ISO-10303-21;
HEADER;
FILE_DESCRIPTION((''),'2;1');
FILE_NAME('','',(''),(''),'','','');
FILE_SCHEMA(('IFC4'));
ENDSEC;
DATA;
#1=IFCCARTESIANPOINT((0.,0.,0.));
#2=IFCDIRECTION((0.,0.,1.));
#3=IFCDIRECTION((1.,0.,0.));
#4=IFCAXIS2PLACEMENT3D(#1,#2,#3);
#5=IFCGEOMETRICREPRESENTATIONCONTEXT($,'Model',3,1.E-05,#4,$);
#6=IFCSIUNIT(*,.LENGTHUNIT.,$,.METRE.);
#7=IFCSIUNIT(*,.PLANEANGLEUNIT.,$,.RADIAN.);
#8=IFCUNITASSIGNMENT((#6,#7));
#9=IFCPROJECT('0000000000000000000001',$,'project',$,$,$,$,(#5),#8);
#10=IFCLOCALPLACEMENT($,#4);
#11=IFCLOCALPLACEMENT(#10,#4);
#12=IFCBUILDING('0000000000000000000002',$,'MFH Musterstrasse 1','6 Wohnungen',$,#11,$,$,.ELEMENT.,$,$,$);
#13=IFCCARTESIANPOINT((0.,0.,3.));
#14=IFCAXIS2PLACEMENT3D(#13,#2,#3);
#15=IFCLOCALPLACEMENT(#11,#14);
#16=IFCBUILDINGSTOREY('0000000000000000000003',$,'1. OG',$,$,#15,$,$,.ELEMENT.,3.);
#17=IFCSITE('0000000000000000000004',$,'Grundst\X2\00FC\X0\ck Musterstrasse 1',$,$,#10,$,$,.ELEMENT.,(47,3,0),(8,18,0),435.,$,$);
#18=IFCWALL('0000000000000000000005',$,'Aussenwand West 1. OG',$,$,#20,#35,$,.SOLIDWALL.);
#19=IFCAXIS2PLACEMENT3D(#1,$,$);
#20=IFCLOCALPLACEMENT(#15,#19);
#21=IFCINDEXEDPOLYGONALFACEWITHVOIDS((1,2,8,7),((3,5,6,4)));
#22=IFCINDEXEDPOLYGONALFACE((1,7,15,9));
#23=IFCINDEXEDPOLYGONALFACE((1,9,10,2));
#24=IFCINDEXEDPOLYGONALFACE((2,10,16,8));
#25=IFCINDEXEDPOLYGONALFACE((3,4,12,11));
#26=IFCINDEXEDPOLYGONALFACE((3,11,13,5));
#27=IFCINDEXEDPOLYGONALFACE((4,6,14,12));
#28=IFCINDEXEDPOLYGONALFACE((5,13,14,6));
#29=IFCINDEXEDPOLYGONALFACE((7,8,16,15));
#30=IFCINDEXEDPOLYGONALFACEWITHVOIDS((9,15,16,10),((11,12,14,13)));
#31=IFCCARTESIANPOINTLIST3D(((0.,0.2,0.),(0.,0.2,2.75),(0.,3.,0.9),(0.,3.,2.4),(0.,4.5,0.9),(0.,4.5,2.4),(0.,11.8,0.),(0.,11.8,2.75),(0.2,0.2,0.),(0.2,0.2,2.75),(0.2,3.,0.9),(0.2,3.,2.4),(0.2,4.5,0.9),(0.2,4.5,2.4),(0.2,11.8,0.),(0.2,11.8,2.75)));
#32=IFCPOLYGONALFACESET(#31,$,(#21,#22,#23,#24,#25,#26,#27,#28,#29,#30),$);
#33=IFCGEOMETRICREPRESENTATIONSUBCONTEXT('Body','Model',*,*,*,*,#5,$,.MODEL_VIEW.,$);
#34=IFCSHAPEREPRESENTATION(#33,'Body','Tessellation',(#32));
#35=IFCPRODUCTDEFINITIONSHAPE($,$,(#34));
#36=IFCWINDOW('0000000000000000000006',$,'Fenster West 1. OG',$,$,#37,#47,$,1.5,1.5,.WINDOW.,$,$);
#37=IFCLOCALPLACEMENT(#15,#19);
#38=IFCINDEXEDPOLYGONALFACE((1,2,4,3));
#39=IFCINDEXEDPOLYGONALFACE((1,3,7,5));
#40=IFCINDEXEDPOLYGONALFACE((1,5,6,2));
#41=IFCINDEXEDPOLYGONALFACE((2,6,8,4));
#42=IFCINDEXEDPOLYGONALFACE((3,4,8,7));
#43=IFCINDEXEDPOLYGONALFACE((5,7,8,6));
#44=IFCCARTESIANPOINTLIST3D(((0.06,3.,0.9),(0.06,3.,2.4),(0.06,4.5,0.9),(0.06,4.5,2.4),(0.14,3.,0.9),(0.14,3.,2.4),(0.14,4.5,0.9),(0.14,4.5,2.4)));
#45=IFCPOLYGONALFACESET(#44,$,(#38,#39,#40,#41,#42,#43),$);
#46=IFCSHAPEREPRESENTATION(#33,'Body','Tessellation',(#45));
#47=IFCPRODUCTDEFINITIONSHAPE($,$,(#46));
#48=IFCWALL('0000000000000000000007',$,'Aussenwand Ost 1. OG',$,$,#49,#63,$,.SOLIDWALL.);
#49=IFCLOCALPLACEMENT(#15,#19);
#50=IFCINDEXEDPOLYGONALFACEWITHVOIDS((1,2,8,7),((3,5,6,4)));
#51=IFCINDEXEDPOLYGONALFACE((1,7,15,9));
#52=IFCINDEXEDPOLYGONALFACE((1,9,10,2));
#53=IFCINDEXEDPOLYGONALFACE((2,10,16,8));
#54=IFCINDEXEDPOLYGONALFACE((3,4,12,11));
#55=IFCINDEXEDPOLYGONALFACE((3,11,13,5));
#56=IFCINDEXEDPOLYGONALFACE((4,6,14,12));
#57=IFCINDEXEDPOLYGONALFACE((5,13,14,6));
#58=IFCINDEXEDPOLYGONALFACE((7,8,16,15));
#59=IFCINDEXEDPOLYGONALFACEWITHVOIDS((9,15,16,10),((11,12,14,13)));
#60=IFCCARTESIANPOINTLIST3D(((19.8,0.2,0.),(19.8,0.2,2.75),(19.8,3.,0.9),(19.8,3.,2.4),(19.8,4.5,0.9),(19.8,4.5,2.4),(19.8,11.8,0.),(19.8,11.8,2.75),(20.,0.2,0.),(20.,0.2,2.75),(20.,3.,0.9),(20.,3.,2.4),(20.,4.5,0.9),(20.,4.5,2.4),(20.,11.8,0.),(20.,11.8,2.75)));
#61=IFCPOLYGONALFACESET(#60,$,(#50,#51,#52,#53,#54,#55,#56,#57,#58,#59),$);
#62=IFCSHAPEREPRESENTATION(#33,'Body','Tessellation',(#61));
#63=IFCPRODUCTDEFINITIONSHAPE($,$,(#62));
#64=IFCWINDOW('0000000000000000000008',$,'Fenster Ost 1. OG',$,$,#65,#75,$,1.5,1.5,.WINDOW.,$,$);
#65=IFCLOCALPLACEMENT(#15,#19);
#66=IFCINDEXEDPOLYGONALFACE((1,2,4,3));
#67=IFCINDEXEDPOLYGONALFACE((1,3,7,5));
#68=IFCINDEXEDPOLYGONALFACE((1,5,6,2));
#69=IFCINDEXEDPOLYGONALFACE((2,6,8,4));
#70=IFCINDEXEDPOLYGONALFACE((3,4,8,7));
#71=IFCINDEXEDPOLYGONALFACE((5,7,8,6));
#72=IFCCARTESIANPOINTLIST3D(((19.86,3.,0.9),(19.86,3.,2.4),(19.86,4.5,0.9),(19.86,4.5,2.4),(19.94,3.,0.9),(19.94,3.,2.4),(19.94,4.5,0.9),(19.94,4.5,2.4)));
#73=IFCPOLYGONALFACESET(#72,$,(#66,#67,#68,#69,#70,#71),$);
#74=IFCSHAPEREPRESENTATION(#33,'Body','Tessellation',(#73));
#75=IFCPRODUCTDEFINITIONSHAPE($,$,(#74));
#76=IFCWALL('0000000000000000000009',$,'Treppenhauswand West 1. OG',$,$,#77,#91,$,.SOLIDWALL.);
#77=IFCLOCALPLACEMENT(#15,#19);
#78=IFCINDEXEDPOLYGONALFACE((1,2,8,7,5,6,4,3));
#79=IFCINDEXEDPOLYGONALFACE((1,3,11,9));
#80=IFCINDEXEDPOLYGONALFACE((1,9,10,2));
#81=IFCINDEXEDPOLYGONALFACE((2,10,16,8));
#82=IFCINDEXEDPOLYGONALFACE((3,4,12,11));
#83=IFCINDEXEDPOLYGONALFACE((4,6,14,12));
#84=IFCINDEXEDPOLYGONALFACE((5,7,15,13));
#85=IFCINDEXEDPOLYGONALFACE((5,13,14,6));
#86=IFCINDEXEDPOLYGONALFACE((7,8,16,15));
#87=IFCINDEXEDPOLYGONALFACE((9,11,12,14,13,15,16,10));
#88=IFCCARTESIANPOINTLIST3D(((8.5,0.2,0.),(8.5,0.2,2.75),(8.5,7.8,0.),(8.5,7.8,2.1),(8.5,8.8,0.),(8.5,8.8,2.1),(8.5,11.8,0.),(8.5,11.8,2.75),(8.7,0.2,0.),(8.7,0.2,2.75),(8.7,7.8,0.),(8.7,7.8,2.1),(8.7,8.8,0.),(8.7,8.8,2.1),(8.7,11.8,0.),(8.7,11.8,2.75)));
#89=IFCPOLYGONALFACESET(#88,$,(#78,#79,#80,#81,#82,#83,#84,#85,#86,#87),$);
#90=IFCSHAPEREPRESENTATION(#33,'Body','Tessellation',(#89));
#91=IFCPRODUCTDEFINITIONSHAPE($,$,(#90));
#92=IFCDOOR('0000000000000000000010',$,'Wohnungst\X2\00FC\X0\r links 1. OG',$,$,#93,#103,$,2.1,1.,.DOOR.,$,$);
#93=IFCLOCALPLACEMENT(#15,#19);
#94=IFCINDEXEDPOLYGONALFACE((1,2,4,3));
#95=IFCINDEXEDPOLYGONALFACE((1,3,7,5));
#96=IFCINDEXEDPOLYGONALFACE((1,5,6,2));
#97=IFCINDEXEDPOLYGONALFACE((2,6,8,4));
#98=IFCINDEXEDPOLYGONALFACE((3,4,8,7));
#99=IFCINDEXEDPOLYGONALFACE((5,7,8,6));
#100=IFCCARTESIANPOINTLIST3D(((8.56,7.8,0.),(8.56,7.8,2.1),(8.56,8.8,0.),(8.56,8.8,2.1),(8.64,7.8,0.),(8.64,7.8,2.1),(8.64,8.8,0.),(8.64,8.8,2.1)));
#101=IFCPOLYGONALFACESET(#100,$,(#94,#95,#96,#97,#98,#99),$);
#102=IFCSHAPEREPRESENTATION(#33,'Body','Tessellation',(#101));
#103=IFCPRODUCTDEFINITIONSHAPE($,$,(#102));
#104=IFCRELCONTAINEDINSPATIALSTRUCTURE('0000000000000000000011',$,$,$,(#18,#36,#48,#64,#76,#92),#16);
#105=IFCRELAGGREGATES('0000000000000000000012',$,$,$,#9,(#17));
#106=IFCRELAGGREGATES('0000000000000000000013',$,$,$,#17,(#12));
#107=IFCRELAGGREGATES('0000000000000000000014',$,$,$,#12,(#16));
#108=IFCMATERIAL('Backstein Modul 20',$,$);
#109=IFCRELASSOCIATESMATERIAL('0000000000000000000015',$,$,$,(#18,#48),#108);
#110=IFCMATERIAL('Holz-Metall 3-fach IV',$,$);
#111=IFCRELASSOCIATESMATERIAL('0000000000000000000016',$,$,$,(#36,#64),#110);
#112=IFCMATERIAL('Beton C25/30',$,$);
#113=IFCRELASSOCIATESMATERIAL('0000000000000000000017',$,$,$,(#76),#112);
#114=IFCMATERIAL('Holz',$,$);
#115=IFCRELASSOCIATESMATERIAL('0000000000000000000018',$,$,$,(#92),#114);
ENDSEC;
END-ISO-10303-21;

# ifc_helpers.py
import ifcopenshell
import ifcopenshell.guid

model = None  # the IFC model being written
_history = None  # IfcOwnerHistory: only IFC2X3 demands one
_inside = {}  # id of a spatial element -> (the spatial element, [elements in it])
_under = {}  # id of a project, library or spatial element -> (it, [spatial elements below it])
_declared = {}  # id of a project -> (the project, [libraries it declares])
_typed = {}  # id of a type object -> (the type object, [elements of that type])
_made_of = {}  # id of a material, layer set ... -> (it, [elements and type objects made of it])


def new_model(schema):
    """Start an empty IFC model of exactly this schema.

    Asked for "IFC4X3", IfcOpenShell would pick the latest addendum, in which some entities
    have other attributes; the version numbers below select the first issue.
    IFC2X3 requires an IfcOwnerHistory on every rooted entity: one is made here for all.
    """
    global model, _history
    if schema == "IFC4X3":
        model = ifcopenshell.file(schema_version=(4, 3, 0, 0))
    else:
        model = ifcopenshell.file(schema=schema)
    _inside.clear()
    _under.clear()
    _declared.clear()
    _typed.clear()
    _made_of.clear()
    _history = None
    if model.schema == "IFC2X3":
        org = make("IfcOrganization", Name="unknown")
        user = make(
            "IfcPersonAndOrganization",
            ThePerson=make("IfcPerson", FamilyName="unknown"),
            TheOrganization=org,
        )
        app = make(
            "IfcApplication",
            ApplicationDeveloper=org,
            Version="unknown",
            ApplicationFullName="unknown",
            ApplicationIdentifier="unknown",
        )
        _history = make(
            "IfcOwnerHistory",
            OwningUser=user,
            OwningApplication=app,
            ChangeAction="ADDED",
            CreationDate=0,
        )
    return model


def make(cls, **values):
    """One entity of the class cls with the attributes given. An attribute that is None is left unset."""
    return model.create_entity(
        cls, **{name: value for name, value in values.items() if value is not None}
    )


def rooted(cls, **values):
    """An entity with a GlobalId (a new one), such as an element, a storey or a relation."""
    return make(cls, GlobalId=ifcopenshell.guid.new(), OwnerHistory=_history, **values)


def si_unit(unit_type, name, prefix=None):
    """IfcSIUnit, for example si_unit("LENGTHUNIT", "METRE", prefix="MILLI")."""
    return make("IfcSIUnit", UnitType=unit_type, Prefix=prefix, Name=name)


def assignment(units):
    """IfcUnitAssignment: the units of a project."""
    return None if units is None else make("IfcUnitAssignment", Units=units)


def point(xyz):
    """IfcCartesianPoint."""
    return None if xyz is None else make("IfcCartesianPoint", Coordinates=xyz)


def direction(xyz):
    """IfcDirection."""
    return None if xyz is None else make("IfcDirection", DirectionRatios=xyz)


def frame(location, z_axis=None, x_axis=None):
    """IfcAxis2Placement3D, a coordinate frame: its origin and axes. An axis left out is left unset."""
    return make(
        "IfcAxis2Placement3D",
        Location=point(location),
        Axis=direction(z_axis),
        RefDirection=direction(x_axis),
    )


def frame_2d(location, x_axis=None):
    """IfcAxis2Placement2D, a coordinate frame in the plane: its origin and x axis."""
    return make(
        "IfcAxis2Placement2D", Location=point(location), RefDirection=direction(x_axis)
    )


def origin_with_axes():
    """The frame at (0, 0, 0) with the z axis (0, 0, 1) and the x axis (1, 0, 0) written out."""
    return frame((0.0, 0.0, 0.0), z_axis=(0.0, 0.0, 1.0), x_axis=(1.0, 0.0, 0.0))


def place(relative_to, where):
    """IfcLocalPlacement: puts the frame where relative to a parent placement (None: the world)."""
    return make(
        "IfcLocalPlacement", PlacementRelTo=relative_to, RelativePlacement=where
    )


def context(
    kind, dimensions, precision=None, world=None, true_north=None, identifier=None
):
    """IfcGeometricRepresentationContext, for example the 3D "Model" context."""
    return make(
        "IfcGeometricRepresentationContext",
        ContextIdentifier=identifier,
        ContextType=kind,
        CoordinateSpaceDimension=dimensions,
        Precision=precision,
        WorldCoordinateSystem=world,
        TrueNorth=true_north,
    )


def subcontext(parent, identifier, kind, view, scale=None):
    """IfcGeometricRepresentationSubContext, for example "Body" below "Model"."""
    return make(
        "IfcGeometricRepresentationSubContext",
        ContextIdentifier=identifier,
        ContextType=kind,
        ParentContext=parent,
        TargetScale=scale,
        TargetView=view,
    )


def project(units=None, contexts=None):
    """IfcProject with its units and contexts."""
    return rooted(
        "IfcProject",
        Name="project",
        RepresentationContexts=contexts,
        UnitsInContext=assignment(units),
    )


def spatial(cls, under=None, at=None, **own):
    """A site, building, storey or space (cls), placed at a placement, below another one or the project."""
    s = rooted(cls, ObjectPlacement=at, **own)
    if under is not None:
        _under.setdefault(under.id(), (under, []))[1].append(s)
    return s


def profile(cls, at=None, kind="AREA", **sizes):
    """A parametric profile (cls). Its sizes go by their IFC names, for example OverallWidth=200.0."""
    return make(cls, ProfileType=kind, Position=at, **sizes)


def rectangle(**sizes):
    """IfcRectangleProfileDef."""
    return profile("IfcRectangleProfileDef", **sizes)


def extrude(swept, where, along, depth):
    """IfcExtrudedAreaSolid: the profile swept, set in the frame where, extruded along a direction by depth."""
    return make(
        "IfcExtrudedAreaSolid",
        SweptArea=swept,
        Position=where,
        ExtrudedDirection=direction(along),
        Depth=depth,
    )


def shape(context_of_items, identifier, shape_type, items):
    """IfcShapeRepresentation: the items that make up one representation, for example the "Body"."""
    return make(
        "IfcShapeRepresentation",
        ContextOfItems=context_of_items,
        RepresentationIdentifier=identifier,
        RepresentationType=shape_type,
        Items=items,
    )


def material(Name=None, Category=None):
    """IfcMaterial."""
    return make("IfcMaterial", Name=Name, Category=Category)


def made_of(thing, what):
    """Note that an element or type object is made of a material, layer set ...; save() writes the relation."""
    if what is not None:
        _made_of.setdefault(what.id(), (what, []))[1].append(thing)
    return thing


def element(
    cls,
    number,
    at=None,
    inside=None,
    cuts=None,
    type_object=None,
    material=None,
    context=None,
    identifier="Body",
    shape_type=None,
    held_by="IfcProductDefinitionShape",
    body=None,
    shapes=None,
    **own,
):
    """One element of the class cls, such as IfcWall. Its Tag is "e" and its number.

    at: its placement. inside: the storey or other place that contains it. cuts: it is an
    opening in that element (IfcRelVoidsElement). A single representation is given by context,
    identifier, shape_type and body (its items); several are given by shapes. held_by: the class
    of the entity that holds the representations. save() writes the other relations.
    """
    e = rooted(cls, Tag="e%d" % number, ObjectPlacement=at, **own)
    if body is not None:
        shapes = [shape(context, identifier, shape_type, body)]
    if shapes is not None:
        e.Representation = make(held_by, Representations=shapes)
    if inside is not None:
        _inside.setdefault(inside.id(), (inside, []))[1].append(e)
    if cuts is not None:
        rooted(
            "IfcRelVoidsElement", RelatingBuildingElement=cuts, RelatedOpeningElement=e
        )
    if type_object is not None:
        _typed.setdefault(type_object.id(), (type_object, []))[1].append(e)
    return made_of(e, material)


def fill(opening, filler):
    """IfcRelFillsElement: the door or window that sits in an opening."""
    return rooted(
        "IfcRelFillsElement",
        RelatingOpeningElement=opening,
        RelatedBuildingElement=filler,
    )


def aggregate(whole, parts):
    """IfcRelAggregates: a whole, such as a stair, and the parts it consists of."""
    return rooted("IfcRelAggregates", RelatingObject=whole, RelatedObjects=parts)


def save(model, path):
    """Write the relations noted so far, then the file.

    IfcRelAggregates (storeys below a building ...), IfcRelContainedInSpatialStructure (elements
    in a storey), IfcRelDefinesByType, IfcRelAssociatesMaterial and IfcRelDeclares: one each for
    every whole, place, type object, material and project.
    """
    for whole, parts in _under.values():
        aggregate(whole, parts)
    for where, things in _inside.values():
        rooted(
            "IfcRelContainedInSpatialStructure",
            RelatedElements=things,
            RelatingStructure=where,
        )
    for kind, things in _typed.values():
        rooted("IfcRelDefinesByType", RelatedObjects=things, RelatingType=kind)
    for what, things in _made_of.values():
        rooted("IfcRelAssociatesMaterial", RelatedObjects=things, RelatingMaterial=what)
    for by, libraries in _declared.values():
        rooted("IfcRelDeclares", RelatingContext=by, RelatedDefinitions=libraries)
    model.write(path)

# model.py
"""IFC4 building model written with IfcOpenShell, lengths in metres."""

from ifc_helpers import new_model, si_unit, frame, frame_2d, origin_with_axes, place, context, subcontext, project, spatial, rectangle, extrude, material, element, fill, save


model = new_model("IFC4")

# Units and contexts
model_context = context("Model", 3, precision=1e-05, world=origin_with_axes())
body_context = subcontext(model_context, "Body", "Model", "MODEL_VIEW")
ifc_project = project(units=[si_unit("LENGTHUNIT", "METRE"), si_unit("PLANEANGLEUNIT", "RADIAN")], contexts=[model_context])

# Site, building, storey
site_placement = place(None, origin_with_axes())
site = spatial("IfcSite", under=ifc_project, at=site_placement, Name="Grundstück Musterstrasse 1", CompositionType="ELEMENT", RefLatitude=(47, 3, 0), RefLongitude=(8, 18, 0), RefElevation=435.0)
building_placement = place(site_placement, origin_with_axes())
building = spatial("IfcBuilding", under=site, at=building_placement, Name="MFH Musterstrasse 1", Description="6 Wohnungen", CompositionType="ELEMENT")
storey_placement = place(building_placement, frame((0.0, 0.0, 3.0), z_axis=(0.0, 0.0, 1.0), x_axis=(1.0, 0.0, 0.0)))
storey = spatial("IfcBuildingStorey", under=building, at=storey_placement, Name="1. OG", CompositionType="ELEMENT", Elevation=3.0)

# Walls, openings, windows
ifc_material_1 = material(Name="Backstein Modul 20")
wall_1_placement = place(storey_placement, origin_with_axes())
wall_1 = element("IfcWall", 1, at=wall_1_placement, inside=storey, material=ifc_material_1, Name="Aussenwand West 1. OG", PredefinedType="SOLIDWALL", context=body_context, shape_type="SweptSolid", body=[
    extrude(rectangle(XDim=0.2, YDim=11.6, at=frame_2d((0.1, 5.8), x_axis=(1.0, 0.0))), frame((0.0, 0.2, 0.0), z_axis=(0.0, 0.0, 1.0), x_axis=(1.0, 0.0, 0.0)), (0.0, 0.0, 1.0), 2.75),
])
opening_1_placement = place(storey_placement, origin_with_axes())
element("IfcOpeningElement", 2, at=opening_1_placement, cuts=wall_1, PredefinedType="OPENING", context=body_context, shape_type="SweptSolid", body=[
    extrude(rectangle(XDim=0.3, YDim=1.5, at=frame_2d((0.15, 0.75), x_axis=(1.0, 0.0))), frame((-0.05, 3.0, 0.9), z_axis=(0.0, 0.0, 1.0), x_axis=(1.0, 0.0, 0.0)), (0.0, 0.0, 1.0), 1.5),
])
opening_2_placement = place(storey_placement, origin_with_axes())
opening_2 = element("IfcOpeningElement", 3, at=opening_2_placement, cuts=wall_1, PredefinedType="OPENING", context=body_context, shape_type="SweptSolid", body=[
    extrude(rectangle(XDim=0.22, YDim=1.5, at=frame_2d((0.11, 0.75), x_axis=(1.0, 0.0))), frame((-0.01, 3.0, 0.9), z_axis=(0.0, 0.0, 1.0), x_axis=(1.0, 0.0, 0.0)), (0.0, 0.0, 1.0), 1.5),
])
ifc_material_2 = material(Name="Holz-Metall 3-fach IV")
window_1_placement = place(storey_placement, origin_with_axes())
window_1 = element("IfcWindow", 4, at=window_1_placement, inside=storey, material=ifc_material_2, Name="Fenster West 1. OG", OverallHeight=1.5, OverallWidth=1.5, PredefinedType="WINDOW", context=body_context, shape_type="SweptSolid", body=[
    extrude(rectangle(XDim=0.08, YDim=1.5, at=frame_2d((0.04, 0.75), x_axis=(1.0, 0.0))), frame((0.06, 3.0, 0.9), z_axis=(0.0, 0.0, 1.0), x_axis=(1.0, 0.0, 0.0)), (0.0, 0.0, 1.0), 1.5),
])
fill(opening_2, window_1)
wall_2_placement = place(storey_placement, origin_with_axes())
wall_2 = element("IfcWall", 5, at=wall_2_placement, inside=storey, material=ifc_material_1, Name="Aussenwand Ost 1. OG", PredefinedType="SOLIDWALL", context=body_context, shape_type="SweptSolid", body=[
    extrude(rectangle(XDim=0.2, YDim=11.6, at=frame_2d((0.1, 5.8), x_axis=(1.0, 0.0))), frame((19.8, 0.2, 0.0), z_axis=(0.0, 0.0, 1.0), x_axis=(1.0, 0.0, 0.0)), (0.0, 0.0, 1.0), 2.75),
])
opening_3_placement = place(storey_placement, origin_with_axes())
element("IfcOpeningElement", 6, at=opening_3_placement, cuts=wall_2, PredefinedType="OPENING", context=body_context, shape_type="SweptSolid", body=[
    extrude(rectangle(XDim=0.3, YDim=1.5, at=frame_2d((0.15, 0.75), x_axis=(1.0, 0.0))), frame((19.75, 3.0, 0.9), z_axis=(0.0, 0.0, 1.0), x_axis=(1.0, 0.0, 0.0)), (0.0, 0.0, 1.0), 1.5),
])
opening_4_placement = place(storey_placement, origin_with_axes())
opening_4 = element("IfcOpeningElement", 7, at=opening_4_placement, cuts=wall_2, PredefinedType="OPENING", context=body_context, shape_type="SweptSolid", body=[
    extrude(rectangle(XDim=0.22, YDim=1.5, at=frame_2d((0.11, 0.75), x_axis=(1.0, 0.0))), frame((19.79, 3.0, 0.9), z_axis=(0.0, 0.0, 1.0), x_axis=(1.0, 0.0, 0.0)), (0.0, 0.0, 1.0), 1.5),
])
window_2_placement = place(storey_placement, origin_with_axes())
window_2 = element("IfcWindow", 8, at=window_2_placement, inside=storey, material=ifc_material_2, Name="Fenster Ost 1. OG", OverallHeight=1.5, OverallWidth=1.5, PredefinedType="WINDOW", context=body_context, shape_type="SweptSolid", body=[
    extrude(rectangle(XDim=0.08, YDim=1.5, at=frame_2d((0.04, 0.75), x_axis=(1.0, 0.0))), frame((19.86, 3.0, 0.9), z_axis=(0.0, 0.0, 1.0), x_axis=(1.0, 0.0, 0.0)), (0.0, 0.0, 1.0), 1.5),
])
fill(opening_4, window_2)

# Wall, openings, door
ifc_material_3 = material(Name="Beton C25/30")
wall_3_placement = place(storey_placement, origin_with_axes())
wall_3 = element("IfcWall", 9, at=wall_3_placement, inside=storey, material=ifc_material_3, Name="Treppenhauswand West 1. OG", PredefinedType="SOLIDWALL", context=body_context, shape_type="SweptSolid", body=[
    extrude(rectangle(XDim=0.2, YDim=11.6, at=frame_2d((0.1, 5.8), x_axis=(1.0, 0.0))), frame((8.5, 0.2, 0.0), z_axis=(0.0, 0.0, 1.0), x_axis=(1.0, 0.0, 0.0)), (0.0, 0.0, 1.0), 2.75),
])
opening_5_placement = place(storey_placement, origin_with_axes())
element("IfcOpeningElement", 10, at=opening_5_placement, cuts=wall_3, PredefinedType="OPENING", context=body_context, shape_type="SweptSolid", body=[
    extrude(rectangle(XDim=0.3, YDim=1.0, at=frame_2d((0.15, 0.5), x_axis=(1.0, 0.0))), frame((8.45, 7.8, 0.0), z_axis=(0.0, 0.0, 1.0), x_axis=(1.0, 0.0, 0.0)), (0.0, 0.0, 1.0), 2.1),
])
opening_6_placement = place(storey_placement, origin_with_axes())
opening_6 = element("IfcOpeningElement", 11, at=opening_6_placement, cuts=wall_3, PredefinedType="OPENING", context=body_context, shape_type="SweptSolid", body=[
    extrude(rectangle(XDim=0.22, YDim=1.0, at=frame_2d((0.11, 0.5), x_axis=(1.0, 0.0))), frame((8.49, 7.8, 0.0), z_axis=(0.0, 0.0, 1.0), x_axis=(1.0, 0.0, 0.0)), (0.0, 0.0, 1.0), 2.1),
])
ifc_material_4 = material(Name="Holz")
door_placement = place(storey_placement, origin_with_axes())
door = element("IfcDoor", 12, at=door_placement, inside=storey, material=ifc_material_4, Name="Wohnungstür links 1. OG", OverallHeight=2.1, OverallWidth=1.0, PredefinedType="DOOR", context=body_context, shape_type="SweptSolid", body=[
    extrude(rectangle(XDim=0.08, YDim=1.0, at=frame_2d((0.04, 0.5), x_axis=(1.0, 0.0))), frame((8.56, 7.8, 0.0), z_axis=(0.0, 0.0, 1.0), x_axis=(1.0, 0.0, 0.0)), (0.0, 0.0, 1.0), 2.1),
])
fill(opening_6, door)

save(model, "model.ifc")
